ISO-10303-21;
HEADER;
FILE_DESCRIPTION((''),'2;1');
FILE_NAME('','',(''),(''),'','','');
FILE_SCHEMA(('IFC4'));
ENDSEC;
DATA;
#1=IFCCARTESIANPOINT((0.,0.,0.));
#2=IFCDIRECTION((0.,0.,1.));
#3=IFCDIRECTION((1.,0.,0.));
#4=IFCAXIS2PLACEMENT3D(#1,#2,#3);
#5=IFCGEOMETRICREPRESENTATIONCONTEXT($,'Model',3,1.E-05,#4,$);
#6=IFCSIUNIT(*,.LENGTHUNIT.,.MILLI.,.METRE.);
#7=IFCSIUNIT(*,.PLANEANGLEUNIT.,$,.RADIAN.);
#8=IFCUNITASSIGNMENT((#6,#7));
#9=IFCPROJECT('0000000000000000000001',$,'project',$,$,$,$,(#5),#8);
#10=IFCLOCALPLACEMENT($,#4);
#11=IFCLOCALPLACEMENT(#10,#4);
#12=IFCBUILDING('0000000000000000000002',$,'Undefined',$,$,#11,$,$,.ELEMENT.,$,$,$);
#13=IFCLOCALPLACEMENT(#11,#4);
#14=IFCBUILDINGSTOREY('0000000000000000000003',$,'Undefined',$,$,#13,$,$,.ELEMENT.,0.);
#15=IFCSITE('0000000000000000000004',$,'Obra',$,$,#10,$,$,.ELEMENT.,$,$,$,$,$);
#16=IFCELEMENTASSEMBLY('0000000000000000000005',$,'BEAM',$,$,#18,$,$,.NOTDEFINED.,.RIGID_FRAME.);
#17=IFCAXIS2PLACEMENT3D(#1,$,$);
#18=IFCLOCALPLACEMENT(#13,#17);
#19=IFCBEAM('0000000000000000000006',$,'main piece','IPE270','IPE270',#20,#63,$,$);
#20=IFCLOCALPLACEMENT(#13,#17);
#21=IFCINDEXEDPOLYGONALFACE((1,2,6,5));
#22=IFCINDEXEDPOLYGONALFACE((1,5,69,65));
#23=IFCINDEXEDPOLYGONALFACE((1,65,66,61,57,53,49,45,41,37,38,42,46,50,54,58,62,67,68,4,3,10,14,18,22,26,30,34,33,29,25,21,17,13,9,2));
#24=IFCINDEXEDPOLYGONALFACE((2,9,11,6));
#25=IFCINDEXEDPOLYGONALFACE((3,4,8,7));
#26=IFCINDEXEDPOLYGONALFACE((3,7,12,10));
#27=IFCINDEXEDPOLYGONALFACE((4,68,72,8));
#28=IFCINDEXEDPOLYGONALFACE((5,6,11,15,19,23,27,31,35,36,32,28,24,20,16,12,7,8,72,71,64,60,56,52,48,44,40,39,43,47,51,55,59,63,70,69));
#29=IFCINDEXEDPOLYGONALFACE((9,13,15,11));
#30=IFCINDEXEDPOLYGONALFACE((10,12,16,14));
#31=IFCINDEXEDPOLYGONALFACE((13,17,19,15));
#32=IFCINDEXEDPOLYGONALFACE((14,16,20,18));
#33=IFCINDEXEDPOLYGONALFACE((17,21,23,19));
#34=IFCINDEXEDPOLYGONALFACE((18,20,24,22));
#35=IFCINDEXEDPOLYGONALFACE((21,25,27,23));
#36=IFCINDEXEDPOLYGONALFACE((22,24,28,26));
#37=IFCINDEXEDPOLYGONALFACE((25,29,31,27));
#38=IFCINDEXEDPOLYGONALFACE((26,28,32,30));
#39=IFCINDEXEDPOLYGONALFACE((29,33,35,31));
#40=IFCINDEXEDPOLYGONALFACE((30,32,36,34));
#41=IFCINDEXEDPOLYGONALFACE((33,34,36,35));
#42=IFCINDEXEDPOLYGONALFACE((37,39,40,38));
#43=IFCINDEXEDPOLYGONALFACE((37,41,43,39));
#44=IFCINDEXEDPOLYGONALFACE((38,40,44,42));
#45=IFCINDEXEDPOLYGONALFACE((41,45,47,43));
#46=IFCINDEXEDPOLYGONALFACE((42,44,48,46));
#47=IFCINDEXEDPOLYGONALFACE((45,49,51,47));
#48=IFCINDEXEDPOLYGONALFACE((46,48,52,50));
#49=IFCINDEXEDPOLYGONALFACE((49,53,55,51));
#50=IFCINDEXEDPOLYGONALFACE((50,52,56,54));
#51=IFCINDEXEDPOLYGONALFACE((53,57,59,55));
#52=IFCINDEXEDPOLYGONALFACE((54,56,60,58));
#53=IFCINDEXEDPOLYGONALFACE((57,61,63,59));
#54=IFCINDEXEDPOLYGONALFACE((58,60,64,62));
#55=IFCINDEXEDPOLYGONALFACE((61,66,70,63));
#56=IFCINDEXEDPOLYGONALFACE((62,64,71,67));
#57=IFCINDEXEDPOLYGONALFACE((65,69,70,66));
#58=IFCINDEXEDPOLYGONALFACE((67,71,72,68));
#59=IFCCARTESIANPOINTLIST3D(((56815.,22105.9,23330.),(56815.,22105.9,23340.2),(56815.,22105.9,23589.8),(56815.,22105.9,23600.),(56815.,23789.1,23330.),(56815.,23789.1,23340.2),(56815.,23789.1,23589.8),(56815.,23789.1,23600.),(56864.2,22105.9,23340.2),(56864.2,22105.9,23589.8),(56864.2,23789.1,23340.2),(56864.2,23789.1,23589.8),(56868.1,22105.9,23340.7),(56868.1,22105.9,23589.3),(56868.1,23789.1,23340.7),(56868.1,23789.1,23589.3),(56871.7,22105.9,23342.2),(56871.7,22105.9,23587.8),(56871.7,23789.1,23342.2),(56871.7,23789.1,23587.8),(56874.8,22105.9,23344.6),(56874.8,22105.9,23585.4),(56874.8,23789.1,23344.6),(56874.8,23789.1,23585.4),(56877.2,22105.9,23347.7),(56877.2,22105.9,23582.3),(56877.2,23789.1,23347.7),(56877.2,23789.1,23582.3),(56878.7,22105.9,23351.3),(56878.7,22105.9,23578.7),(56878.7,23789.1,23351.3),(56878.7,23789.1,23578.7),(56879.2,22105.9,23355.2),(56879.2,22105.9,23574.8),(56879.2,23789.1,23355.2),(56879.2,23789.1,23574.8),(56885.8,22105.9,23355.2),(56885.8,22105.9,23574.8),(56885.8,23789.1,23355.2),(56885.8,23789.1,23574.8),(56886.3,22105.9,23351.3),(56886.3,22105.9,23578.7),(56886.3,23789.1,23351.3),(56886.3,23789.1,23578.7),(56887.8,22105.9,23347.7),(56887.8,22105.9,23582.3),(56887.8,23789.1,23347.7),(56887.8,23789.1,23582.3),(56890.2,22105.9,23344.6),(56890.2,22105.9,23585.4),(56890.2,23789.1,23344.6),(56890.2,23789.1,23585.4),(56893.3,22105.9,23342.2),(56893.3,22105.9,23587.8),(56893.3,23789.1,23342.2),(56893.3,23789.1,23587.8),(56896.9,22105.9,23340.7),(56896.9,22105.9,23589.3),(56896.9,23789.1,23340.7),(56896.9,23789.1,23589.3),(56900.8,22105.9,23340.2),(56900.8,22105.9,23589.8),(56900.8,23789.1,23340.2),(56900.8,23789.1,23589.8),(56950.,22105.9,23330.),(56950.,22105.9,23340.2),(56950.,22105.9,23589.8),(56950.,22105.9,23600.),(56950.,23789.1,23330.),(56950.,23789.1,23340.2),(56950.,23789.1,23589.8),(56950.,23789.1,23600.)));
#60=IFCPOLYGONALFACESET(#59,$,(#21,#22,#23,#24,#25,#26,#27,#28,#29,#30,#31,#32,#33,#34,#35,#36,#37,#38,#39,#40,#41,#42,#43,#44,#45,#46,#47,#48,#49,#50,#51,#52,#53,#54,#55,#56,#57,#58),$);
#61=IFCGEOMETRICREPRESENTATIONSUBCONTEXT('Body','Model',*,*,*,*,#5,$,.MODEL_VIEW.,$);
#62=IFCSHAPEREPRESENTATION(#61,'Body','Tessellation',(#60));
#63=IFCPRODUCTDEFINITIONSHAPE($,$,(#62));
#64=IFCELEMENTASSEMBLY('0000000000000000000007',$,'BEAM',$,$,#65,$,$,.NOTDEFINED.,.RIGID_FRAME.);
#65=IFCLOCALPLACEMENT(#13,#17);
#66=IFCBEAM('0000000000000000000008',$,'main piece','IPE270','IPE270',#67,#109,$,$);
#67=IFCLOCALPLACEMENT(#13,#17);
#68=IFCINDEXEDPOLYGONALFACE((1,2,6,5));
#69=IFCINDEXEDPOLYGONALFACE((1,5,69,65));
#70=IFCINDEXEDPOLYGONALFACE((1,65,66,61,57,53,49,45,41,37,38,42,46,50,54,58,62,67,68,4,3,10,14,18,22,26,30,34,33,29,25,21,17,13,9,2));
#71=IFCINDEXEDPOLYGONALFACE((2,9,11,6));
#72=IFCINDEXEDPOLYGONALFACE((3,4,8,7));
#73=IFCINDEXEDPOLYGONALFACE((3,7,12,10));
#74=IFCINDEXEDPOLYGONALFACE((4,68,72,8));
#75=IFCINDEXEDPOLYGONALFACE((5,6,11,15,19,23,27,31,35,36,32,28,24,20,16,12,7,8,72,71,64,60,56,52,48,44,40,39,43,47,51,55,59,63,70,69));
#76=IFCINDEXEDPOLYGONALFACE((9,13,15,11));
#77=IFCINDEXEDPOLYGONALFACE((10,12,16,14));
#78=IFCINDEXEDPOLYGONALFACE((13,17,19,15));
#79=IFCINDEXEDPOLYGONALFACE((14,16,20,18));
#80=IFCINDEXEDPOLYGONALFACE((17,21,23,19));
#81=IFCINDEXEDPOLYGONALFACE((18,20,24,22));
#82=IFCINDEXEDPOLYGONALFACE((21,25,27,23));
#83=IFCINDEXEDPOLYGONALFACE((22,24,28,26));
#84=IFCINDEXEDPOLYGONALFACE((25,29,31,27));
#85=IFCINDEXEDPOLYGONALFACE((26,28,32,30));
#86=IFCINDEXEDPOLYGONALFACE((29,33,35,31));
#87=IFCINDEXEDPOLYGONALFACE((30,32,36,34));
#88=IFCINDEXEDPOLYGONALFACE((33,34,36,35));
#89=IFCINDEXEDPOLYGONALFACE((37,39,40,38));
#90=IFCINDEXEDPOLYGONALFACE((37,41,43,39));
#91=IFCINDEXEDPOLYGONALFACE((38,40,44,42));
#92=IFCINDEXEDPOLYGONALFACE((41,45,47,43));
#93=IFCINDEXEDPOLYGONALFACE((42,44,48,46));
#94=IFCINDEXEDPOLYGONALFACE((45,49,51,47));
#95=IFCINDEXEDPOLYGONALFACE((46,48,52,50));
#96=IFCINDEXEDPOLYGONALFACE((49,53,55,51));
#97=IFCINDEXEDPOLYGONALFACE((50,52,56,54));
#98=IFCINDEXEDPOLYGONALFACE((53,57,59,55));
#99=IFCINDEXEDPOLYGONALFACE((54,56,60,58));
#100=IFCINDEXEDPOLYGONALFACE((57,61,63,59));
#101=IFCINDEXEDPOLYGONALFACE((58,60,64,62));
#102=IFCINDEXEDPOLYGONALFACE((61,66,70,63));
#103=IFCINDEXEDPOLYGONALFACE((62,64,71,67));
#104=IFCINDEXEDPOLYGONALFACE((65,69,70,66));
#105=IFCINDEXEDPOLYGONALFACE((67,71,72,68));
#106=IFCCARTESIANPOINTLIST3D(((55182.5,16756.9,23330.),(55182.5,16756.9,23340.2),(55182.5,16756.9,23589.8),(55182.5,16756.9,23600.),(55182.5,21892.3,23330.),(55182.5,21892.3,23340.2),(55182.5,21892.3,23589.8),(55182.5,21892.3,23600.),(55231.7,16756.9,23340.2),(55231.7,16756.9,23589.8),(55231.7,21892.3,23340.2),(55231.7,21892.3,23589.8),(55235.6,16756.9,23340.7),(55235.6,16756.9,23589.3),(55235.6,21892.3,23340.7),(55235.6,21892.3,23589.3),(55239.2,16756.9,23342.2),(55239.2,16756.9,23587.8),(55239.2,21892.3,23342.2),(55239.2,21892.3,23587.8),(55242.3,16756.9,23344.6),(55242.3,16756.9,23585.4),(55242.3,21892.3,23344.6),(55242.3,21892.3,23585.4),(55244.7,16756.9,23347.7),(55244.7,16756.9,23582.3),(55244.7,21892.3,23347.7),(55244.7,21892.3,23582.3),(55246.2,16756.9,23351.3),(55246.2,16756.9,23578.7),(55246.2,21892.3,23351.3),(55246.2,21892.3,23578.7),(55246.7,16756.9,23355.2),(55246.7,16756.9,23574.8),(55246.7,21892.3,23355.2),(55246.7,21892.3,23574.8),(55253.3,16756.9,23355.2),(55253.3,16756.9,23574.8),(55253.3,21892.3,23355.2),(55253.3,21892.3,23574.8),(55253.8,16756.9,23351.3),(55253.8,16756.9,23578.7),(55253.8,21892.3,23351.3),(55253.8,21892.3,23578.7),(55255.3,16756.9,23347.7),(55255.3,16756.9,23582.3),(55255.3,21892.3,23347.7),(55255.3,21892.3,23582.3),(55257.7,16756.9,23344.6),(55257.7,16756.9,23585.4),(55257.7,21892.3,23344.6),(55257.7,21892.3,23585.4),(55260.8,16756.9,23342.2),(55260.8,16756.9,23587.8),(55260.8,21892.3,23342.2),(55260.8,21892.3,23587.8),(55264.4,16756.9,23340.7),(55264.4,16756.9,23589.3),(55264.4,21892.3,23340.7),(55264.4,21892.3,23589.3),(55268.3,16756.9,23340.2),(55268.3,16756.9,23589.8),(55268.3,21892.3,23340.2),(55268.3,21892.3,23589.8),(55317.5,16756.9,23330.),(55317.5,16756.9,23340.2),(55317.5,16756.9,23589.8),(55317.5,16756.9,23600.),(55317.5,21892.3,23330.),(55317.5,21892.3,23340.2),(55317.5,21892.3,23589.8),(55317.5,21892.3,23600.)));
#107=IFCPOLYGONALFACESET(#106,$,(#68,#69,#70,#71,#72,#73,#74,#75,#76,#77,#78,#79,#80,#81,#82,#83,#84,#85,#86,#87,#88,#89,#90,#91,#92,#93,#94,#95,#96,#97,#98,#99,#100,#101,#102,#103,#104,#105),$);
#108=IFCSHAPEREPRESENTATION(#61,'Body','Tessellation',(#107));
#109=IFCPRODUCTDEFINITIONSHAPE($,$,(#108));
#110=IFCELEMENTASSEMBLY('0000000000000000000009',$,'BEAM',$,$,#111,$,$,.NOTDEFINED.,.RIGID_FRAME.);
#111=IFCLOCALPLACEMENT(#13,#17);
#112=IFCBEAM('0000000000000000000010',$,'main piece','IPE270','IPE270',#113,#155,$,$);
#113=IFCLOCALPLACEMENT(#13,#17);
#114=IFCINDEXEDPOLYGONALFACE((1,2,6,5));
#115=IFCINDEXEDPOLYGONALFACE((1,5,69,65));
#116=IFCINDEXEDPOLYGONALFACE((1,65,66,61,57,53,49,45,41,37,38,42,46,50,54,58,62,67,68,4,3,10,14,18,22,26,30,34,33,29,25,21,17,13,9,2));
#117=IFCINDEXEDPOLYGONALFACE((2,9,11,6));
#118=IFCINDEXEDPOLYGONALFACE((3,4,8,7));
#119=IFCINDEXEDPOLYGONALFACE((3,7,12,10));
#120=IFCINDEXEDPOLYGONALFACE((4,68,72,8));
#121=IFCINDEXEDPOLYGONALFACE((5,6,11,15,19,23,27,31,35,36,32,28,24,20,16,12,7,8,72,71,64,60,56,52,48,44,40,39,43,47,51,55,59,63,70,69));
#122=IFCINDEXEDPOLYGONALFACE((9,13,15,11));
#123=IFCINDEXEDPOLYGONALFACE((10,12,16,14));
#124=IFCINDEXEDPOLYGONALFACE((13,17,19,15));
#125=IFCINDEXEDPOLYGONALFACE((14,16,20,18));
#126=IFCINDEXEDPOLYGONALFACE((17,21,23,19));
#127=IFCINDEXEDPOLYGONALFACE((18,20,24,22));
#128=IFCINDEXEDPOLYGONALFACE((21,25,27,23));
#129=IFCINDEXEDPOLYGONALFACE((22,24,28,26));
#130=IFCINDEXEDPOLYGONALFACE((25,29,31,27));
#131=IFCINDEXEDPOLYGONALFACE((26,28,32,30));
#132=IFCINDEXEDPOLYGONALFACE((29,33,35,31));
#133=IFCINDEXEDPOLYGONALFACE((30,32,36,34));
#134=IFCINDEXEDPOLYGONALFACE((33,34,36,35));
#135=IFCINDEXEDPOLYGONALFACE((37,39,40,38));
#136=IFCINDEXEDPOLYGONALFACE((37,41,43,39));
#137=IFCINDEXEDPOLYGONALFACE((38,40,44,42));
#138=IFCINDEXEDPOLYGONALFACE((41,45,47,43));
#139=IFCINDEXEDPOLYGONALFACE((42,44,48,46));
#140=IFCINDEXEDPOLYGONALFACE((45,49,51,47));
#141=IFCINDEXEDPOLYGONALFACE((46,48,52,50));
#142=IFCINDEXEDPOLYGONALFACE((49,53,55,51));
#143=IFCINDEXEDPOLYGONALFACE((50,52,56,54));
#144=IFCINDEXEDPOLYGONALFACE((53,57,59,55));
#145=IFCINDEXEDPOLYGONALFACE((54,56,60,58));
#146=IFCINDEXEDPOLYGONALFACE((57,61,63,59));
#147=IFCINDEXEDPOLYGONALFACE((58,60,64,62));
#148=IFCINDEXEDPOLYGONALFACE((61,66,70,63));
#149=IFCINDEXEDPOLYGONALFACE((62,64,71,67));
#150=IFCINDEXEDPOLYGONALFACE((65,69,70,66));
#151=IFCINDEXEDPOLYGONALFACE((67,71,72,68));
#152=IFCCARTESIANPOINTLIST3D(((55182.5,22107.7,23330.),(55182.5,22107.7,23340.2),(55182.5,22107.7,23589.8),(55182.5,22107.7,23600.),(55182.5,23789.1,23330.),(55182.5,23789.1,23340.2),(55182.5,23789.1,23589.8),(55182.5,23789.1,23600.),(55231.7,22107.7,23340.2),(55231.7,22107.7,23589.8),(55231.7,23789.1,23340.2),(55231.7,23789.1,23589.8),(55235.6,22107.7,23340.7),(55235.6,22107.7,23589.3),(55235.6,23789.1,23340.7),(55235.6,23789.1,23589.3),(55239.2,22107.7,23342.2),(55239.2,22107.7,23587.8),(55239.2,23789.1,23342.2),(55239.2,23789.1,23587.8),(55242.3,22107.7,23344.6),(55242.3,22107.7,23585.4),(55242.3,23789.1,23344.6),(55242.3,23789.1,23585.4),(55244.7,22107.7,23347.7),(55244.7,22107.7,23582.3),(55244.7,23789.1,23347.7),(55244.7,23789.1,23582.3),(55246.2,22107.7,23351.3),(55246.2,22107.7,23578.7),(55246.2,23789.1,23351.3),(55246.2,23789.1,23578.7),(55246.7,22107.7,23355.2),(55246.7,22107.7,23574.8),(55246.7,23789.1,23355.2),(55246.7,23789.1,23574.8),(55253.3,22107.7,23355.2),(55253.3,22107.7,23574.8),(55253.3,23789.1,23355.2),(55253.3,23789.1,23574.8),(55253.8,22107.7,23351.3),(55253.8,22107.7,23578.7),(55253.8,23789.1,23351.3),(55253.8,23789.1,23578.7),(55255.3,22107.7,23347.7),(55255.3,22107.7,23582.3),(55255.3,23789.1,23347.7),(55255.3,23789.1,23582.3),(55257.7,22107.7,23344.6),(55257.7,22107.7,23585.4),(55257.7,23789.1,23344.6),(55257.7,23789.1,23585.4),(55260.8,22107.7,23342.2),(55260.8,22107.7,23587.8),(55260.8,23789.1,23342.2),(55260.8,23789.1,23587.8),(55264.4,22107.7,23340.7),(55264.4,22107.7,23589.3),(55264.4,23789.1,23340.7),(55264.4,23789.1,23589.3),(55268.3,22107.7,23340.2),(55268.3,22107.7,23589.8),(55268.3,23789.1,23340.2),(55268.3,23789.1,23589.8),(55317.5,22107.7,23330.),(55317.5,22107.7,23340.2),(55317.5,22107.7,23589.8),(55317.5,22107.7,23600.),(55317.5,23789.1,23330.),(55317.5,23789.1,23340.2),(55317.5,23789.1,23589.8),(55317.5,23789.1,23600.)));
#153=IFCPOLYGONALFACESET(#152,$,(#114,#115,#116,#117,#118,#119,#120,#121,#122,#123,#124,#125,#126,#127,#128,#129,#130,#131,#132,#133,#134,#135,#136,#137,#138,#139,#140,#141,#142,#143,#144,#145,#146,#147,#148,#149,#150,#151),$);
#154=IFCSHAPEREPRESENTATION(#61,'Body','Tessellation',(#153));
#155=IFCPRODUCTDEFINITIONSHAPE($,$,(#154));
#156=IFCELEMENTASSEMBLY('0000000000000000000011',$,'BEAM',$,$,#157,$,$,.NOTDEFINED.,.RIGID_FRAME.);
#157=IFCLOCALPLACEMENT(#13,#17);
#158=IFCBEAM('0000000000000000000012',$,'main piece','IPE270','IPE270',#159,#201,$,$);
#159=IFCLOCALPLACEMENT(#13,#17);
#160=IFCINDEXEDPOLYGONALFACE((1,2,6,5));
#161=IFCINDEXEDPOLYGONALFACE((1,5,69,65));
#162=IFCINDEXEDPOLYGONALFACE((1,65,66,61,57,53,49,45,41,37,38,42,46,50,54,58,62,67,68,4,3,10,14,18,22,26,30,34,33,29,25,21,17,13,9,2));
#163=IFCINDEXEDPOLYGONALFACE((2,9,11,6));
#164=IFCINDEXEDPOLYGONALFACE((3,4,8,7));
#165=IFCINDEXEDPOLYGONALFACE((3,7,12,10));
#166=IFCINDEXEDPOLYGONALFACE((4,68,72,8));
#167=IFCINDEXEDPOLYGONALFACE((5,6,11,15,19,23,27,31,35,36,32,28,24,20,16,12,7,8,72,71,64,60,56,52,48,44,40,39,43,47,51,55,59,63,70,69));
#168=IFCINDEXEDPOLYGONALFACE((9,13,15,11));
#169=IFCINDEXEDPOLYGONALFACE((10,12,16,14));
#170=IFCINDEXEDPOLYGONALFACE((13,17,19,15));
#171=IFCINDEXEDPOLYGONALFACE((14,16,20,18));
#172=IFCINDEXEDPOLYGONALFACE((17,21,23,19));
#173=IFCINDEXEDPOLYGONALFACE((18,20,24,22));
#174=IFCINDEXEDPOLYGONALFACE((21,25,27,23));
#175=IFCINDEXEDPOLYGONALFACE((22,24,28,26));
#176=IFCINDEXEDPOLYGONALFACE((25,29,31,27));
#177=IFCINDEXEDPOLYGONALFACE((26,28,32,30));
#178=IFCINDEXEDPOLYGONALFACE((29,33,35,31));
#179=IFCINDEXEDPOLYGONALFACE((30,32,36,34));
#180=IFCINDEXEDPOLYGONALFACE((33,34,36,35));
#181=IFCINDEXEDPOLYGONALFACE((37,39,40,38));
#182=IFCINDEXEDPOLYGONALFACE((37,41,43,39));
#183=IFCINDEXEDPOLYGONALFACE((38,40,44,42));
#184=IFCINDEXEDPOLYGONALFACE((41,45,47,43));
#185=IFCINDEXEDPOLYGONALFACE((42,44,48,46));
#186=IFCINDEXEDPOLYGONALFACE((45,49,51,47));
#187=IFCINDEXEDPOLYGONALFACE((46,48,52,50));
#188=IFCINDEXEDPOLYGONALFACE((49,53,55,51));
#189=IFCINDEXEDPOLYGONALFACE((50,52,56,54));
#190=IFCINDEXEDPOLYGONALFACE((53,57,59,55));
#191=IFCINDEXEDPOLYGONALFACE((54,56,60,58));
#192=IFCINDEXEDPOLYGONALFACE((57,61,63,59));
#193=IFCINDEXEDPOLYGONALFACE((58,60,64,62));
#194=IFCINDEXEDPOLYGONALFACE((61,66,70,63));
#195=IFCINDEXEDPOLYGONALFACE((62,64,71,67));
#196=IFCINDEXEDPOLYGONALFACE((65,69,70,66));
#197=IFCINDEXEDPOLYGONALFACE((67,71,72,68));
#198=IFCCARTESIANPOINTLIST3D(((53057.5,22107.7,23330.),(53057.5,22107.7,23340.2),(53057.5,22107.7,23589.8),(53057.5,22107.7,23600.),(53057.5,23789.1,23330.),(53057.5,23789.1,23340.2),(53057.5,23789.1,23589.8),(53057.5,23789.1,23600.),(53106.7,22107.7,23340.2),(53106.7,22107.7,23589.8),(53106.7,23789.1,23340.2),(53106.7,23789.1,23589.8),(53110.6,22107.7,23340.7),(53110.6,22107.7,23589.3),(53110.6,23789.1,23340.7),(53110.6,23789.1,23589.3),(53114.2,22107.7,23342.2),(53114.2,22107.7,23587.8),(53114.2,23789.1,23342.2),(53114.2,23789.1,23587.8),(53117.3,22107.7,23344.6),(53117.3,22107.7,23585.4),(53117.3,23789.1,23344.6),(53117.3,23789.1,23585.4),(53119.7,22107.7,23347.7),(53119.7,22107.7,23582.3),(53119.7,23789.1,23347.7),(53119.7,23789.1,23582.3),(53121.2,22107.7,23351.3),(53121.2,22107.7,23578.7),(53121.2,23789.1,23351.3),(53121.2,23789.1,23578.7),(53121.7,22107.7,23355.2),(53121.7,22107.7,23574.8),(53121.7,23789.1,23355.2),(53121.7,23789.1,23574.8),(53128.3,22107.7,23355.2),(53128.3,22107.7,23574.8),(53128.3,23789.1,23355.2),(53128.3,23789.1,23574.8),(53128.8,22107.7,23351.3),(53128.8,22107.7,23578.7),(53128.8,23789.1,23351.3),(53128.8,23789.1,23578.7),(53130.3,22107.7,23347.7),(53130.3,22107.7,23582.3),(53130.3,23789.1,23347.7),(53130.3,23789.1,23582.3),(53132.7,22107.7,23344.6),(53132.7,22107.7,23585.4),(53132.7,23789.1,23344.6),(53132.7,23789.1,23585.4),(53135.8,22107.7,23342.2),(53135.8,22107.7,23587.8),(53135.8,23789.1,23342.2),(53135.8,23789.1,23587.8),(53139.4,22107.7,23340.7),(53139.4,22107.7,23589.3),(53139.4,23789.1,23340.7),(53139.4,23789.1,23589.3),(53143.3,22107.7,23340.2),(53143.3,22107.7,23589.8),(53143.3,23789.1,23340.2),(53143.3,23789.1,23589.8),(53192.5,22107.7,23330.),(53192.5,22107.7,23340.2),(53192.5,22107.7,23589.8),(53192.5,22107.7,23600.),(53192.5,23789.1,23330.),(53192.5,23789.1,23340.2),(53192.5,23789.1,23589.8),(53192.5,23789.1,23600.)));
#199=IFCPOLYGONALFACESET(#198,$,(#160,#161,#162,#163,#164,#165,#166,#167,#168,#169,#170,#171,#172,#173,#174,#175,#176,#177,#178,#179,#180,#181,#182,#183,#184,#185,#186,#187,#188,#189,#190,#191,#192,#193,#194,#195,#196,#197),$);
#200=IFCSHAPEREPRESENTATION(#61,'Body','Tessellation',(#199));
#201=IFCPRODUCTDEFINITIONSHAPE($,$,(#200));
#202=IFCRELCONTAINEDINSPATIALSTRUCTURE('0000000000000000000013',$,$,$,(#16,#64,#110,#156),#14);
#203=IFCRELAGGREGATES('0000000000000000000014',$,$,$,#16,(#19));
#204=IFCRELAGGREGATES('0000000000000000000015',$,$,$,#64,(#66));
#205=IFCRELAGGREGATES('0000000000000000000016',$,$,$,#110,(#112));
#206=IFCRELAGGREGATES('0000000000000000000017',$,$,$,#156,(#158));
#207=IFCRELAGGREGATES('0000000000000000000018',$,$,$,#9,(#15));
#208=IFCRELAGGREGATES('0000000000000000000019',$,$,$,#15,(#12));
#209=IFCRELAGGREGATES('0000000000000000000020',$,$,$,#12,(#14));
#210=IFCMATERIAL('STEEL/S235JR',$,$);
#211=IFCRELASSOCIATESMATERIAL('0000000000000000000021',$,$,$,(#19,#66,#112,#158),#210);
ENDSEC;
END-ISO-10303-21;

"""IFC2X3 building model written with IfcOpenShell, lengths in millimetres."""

from ifc_helpers import new_model, si_unit, frame, origin_with_axes, origin_2d_with_axis, place, context, subcontext, project, spatial, i_section, extrude, clip, halfspace, material, element, aggregate, save


model = new_model("IFC2X3")

# Units and contexts
model_context = context("Model", 3, precision=1e-05, world=origin_with_axes())
body_context = subcontext(model_context, "Body", "Model", "MODEL_VIEW")
ifc_project = project(units=[si_unit("LENGTHUNIT", "METRE", prefix="MILLI"), si_unit("PLANEANGLEUNIT", "RADIAN")], contexts=[model_context])

# Site, building, storey
site_placement = place(None, origin_with_axes())
site = spatial("IfcSite", under=ifc_project, at=site_placement, Name="Obra", CompositionType="ELEMENT")
building_placement = place(site_placement, origin_with_axes())
building = spatial("IfcBuilding", under=site, at=building_placement, Name="Undefined", CompositionType="ELEMENT")
storey_placement = place(building_placement, origin_with_axes())
storey = spatial("IfcBuildingStorey", under=building, at=storey_placement, Name="Undefined", CompositionType="ELEMENT", Elevation=0.0)

# Element assemblies, beams
assembly_1_placement = place(storey_placement, origin_with_axes())
assembly_1 = element("IfcElementAssembly", 1, at=assembly_1_placement, inside=storey, Name="BEAM", AssemblyPlace="NOTDEFINED", PredefinedType="RIGID_FRAME")
ifc_material_1 = material(Name="STEEL/S235JR")
beam_1_placement = place(assembly_1_placement, frame((56882.5, 22105.9, 23465.0), z_axis=(0.0, 0.0, 1.0), x_axis=(0.0, 1.0, 0.0)))
beam_1 = element("IfcBeam", 2, at=beam_1_placement, material=ifc_material_1, Name="main piece", Description="IPE270", ObjectType="IPE270", context=body_context, shape_type="SweptSolid", body=[
    extrude(i_section(OverallWidth=135.0, OverallDepth=270.0, WebThickness=6.6, FlangeThickness=10.2, FilletRadius=15.0, at=origin_2d_with_axis()), frame((1683.2, 0.0, 0.0), z_axis=(-1.0, 0.0, 0.0), x_axis=(0.0, -1.0, 0.0)), (0.0, 0.0, 1.0), 1683.2),
])
aggregate(assembly_1, [beam_1])
assembly_2_placement = place(storey_placement, origin_with_axes())
assembly_2 = element("IfcElementAssembly", 3, at=assembly_2_placement, inside=storey, Name="BEAM", AssemblyPlace="NOTDEFINED", PredefinedType="RIGID_FRAME")
beam_2_placement = place(assembly_2_placement, frame((55250.0, 21892.3, 23465.0), z_axis=(0.0, 0.0, 1.0), x_axis=(0.0, -1.0, 0.0)))
beam_2 = element("IfcBeam", 4, at=beam_2_placement, material=ifc_material_1, Name="main piece", Description="IPE270", ObjectType="IPE270", context=body_context, shape_type="Clipping", body=[
    clip(extrude(i_section(OverallWidth=135.0, OverallDepth=270.0, WebThickness=6.6, FlangeThickness=10.2, FilletRadius=15.0, at=origin_2d_with_axis()), frame((5174.3, 0.0, 0.0), z_axis=(-1.0, 0.0, 0.0), x_axis=(0.0, -1.0, 0.0)), (0.0, 0.0, 1.0), 5174.3), halfspace(frame((5135.4, -60.0, -120.0), z_axis=(1.0, 0.0, 0.0), x_axis=(0.0, 0.0, 1.0)), False)),
])
aggregate(assembly_2, [beam_2])
assembly_3_placement = place(storey_placement, origin_with_axes())
assembly_3 = element("IfcElementAssembly", 5, at=assembly_3_placement, inside=storey, Name="BEAM", AssemblyPlace="NOTDEFINED", PredefinedType="RIGID_FRAME")
beam_3_placement = place(assembly_3_placement, frame((55250.0, 23789.1, 23465.0), z_axis=(0.0, 0.0, 1.0), x_axis=(0.0, -1.0, 0.0)))
beam_3 = element("IfcBeam", 6, at=beam_3_placement, material=ifc_material_1, Name="main piece", Description="IPE270", ObjectType="IPE270", context=body_context, shape_type="SweptSolid", body=[
    extrude(i_section(OverallWidth=135.0, OverallDepth=270.0, WebThickness=6.6, FlangeThickness=10.2, FilletRadius=15.0, at=origin_2d_with_axis()), frame((1681.4, 0.0, 0.0), z_axis=(-1.0, 0.0, 0.0), x_axis=(0.0, -1.0, 0.0)), (0.0, 0.0, 1.0), 1681.4),
])
aggregate(assembly_3, [beam_3])
assembly_4_placement = place(storey_placement, origin_with_axes())
assembly_4 = element("IfcElementAssembly", 7, at=assembly_4_placement, inside=storey, Name="BEAM", AssemblyPlace="NOTDEFINED", PredefinedType="RIGID_FRAME")
beam_4_placement = place(assembly_4_placement, frame((53125.0, 22107.7, 23465.0), z_axis=(0.0, 0.0, 1.0), x_axis=(0.0, 1.0, 0.0)))
beam_4 = element("IfcBeam", 8, at=beam_4_placement, material=ifc_material_1, Name="main piece", Description="IPE270", ObjectType="IPE270", context=body_context, shape_type="SweptSolid", body=[
    extrude(i_section(OverallWidth=135.0, OverallDepth=270.0, WebThickness=6.6, FlangeThickness=10.2, FilletRadius=15.0, at=origin_2d_with_axis()), frame((1681.4, 0.0, 0.0), z_axis=(-1.0, 0.0, 0.0), x_axis=(0.0, -1.0, 0.0)), (0.0, 0.0, 1.0), 1681.4),
])
aggregate(assembly_4, [beam_4])

save(model, "model.ifc")
